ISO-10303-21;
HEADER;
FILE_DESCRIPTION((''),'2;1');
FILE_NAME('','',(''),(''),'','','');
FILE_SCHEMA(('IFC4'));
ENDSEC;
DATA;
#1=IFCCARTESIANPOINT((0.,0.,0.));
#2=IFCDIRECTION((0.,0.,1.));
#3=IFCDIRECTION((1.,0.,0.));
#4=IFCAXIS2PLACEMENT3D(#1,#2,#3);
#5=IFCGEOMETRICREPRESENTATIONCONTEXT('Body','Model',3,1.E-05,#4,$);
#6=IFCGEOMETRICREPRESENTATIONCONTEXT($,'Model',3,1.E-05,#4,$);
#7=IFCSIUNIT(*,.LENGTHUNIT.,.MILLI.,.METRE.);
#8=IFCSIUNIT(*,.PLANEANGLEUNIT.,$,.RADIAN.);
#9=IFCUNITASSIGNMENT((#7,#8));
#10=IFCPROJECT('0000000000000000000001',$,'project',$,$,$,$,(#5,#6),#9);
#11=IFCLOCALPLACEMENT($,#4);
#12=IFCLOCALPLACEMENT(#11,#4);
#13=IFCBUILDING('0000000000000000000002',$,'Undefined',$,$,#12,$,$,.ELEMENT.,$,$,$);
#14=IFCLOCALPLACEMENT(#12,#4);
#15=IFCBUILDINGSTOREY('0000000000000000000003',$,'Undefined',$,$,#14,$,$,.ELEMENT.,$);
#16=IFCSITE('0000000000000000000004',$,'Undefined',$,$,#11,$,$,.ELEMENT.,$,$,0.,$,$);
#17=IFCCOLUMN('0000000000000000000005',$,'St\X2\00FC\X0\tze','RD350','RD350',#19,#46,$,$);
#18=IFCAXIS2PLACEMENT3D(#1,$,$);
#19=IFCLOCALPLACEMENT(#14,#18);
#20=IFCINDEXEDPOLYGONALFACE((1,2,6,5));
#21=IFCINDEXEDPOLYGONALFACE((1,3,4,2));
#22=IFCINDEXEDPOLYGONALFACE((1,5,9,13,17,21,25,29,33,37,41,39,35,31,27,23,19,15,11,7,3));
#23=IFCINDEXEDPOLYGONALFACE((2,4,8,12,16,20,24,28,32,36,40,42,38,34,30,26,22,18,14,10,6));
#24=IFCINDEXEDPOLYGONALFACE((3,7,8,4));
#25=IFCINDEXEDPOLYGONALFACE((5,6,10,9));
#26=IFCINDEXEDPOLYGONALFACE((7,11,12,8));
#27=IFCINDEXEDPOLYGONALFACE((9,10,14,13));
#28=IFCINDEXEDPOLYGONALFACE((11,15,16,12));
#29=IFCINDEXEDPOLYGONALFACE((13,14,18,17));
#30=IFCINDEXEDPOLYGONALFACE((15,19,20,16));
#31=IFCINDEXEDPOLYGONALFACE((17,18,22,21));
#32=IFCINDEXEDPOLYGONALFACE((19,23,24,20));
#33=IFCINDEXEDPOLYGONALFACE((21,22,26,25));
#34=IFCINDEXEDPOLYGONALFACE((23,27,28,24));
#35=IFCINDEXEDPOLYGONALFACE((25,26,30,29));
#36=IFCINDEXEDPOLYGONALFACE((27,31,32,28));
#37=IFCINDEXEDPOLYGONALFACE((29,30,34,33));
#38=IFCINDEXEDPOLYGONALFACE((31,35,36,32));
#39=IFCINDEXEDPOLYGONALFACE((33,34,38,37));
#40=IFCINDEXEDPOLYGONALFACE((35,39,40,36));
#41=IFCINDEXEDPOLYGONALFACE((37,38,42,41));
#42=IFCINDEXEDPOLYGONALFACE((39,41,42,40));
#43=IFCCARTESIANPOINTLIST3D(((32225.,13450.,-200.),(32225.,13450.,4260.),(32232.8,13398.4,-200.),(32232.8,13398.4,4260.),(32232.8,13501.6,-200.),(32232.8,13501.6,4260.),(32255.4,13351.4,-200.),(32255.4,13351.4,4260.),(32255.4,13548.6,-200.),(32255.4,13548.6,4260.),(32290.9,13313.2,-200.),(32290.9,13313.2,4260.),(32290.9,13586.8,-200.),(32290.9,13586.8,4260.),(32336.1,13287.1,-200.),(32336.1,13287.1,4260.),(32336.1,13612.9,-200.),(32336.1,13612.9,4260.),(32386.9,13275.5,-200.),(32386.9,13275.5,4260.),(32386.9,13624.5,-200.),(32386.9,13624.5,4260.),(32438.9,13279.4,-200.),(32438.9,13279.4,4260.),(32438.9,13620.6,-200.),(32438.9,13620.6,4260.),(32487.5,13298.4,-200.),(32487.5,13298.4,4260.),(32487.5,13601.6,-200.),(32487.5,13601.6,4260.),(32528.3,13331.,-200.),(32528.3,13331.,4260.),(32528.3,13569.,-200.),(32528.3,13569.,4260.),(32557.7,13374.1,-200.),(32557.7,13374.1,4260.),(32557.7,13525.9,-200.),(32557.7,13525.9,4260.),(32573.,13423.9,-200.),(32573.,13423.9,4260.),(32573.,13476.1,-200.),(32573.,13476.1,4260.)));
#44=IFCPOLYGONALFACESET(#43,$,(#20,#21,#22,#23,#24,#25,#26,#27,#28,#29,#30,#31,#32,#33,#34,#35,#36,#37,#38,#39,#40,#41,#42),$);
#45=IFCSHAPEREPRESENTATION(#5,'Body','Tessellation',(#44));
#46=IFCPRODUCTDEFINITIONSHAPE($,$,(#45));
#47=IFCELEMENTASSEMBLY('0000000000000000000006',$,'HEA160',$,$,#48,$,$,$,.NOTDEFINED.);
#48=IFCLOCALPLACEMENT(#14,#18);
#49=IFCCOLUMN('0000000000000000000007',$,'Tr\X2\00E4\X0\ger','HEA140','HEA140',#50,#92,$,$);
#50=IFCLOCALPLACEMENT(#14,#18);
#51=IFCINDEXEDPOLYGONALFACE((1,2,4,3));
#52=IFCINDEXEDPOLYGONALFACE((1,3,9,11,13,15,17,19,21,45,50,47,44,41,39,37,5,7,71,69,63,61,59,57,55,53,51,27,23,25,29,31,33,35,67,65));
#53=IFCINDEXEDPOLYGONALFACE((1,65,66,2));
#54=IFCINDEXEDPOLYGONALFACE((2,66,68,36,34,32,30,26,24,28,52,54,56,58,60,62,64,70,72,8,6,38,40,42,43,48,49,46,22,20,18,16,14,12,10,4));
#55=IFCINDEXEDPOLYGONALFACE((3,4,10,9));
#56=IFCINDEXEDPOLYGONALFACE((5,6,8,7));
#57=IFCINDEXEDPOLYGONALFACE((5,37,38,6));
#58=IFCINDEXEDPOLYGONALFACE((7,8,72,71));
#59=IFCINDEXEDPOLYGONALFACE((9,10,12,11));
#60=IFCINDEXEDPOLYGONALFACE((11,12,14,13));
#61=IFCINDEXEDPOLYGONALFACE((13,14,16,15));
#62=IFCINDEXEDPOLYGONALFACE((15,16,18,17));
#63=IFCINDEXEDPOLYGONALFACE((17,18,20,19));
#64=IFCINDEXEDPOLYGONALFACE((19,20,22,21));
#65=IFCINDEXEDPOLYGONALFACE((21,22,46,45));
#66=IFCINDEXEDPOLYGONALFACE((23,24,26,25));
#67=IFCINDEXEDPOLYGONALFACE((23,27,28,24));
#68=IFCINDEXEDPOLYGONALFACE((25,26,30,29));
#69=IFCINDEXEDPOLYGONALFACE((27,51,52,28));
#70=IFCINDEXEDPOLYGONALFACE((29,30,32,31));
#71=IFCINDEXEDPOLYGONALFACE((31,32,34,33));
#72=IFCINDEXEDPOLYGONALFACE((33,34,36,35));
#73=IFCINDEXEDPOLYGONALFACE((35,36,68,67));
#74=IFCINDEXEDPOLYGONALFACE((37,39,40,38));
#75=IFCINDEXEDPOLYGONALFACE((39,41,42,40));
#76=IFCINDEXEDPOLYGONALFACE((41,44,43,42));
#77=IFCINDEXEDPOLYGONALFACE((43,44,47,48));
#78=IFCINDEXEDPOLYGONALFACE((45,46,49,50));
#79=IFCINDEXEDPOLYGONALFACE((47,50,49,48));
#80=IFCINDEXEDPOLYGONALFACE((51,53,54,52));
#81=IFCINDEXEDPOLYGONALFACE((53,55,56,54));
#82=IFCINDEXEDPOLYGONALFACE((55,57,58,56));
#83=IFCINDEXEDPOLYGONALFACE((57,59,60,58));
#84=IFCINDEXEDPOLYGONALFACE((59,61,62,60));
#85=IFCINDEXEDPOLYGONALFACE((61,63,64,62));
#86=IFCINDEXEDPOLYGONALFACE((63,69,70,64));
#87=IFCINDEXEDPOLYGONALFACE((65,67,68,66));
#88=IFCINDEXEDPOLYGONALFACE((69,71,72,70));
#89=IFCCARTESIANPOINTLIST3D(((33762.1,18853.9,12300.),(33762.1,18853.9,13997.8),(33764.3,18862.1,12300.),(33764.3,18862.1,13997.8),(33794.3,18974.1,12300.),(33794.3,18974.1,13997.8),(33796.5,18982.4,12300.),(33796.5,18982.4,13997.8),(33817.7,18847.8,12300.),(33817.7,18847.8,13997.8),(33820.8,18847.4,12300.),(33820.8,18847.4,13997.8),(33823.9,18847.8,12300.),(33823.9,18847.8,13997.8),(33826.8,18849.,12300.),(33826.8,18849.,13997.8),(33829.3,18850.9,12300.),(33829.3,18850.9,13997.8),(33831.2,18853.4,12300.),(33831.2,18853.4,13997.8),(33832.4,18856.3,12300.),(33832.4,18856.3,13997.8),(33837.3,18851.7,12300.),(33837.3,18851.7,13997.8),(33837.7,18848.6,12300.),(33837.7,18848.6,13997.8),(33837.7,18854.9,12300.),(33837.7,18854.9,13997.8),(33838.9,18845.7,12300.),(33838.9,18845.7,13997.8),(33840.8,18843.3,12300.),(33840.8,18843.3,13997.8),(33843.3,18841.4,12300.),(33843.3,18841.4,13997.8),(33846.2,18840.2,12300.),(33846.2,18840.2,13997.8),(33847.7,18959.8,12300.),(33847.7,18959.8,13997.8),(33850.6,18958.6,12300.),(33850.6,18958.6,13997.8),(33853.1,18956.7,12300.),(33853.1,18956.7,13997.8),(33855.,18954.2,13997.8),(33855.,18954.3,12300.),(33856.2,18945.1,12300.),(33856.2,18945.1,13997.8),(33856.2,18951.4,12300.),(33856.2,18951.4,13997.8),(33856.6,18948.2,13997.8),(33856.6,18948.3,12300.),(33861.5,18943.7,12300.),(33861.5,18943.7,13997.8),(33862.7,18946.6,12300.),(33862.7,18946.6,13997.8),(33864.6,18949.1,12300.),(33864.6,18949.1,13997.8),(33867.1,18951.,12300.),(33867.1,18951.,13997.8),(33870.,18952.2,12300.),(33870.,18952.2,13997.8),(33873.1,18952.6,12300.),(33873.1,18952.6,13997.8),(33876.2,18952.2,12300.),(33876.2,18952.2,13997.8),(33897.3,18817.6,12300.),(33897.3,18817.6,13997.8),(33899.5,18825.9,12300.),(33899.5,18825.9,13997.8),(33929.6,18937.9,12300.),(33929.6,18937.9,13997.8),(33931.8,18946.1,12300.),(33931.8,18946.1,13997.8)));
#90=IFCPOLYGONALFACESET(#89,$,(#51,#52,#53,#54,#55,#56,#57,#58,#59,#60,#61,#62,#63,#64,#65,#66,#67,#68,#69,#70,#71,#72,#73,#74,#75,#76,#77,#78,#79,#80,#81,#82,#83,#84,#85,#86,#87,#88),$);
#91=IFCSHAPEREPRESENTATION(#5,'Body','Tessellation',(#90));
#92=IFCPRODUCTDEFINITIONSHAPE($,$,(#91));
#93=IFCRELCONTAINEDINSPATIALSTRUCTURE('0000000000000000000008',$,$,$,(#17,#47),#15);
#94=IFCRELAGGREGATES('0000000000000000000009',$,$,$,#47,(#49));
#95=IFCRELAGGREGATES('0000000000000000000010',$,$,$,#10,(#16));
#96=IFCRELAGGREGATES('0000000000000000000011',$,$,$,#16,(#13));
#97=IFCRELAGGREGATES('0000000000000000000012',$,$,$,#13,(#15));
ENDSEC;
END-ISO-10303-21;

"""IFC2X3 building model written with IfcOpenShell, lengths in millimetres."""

from ifc_helpers import new_model, si_unit, frame, origin_with_axes, origin_2d_with_axis, place, context, project, spatial, circle, i_section, extrude, element, aggregate, save


model = new_model("IFC2X3")

# Units and contexts
model_context_1 = context("Model", 3, precision=1e-05, world=origin_with_axes(), identifier="Body")
model_context_2 = context("Model", 3, precision=1e-05, world=origin_with_axes())
ifc_project = project(units=[si_unit("LENGTHUNIT", "METRE", prefix="MILLI"), si_unit("PLANEANGLEUNIT", "RADIAN")], contexts=[model_context_1, model_context_2])

# Site, building, storey
site_placement = place(None, origin_with_axes())
site = spatial("IfcSite", under=ifc_project, at=site_placement, Name="Undefined", CompositionType="ELEMENT", RefElevation=0.0)
building_placement = place(site_placement, origin_with_axes())
building = spatial("IfcBuilding", under=site, at=building_placement, Name="Undefined", CompositionType="ELEMENT")
storey_placement = place(building_placement, origin_with_axes())
storey = spatial("IfcBuildingStorey", under=building, at=storey_placement, Name="Undefined", CompositionType="ELEMENT")

# Column
column_1_placement = place(storey_placement, frame((32400.0, 13450.0, -200.0), z_axis=(0.0, 0.0, 1.0), x_axis=(1.0, 0.0, 0.0)))
element("IfcColumn", 1, at=column_1_placement, inside=storey, Name="Stütze", Description="RD350", ObjectType="RD350", context=model_context_1, shape_type="SweptSolid", body=[
    extrude(circle(Radius=175.0, at=origin_2d_with_axis()), frame((0.0, 0.0, 4460.0), z_axis=(0.0, 0.0, -1.0), x_axis=(-1.0, 0.0, 0.0)), (0.0, 0.0, 1.0), 4460.0),
])

# Element assembly, column
assembly_1 = element("IfcElementAssembly", 2, inside=storey, Name="HEA160", PredefinedType="NOTDEFINED")
column_2_placement = place(storey_placement, frame((33846.9, 18900.0, 12224.0), z_axis=(0.0, 0.0, 1.0), x_axis=(1.0, 0.0, 0.0)))
column_2 = element("IfcColumn", 3, at=column_2_placement, Name="Träger", Description="HEA140", ObjectType="HEA140", context=model_context_1, shape_type="SweptSolid", body=[
    extrude(i_section(OverallWidth=140.0, OverallDepth=133.0, WebThickness=5.5, FlangeThickness=8.5, FilletRadius=12.0, at=origin_2d_with_axis()), frame((0.0, 0.0, 1773.8), z_axis=(0.0, 0.0, -1.0), x_axis=(0.965926, -0.258819, 0.0)), (0.0, 0.0, 1.0), 1697.8),
])
aggregate(assembly_1, [column_2])

save(model, "model.ifc")
